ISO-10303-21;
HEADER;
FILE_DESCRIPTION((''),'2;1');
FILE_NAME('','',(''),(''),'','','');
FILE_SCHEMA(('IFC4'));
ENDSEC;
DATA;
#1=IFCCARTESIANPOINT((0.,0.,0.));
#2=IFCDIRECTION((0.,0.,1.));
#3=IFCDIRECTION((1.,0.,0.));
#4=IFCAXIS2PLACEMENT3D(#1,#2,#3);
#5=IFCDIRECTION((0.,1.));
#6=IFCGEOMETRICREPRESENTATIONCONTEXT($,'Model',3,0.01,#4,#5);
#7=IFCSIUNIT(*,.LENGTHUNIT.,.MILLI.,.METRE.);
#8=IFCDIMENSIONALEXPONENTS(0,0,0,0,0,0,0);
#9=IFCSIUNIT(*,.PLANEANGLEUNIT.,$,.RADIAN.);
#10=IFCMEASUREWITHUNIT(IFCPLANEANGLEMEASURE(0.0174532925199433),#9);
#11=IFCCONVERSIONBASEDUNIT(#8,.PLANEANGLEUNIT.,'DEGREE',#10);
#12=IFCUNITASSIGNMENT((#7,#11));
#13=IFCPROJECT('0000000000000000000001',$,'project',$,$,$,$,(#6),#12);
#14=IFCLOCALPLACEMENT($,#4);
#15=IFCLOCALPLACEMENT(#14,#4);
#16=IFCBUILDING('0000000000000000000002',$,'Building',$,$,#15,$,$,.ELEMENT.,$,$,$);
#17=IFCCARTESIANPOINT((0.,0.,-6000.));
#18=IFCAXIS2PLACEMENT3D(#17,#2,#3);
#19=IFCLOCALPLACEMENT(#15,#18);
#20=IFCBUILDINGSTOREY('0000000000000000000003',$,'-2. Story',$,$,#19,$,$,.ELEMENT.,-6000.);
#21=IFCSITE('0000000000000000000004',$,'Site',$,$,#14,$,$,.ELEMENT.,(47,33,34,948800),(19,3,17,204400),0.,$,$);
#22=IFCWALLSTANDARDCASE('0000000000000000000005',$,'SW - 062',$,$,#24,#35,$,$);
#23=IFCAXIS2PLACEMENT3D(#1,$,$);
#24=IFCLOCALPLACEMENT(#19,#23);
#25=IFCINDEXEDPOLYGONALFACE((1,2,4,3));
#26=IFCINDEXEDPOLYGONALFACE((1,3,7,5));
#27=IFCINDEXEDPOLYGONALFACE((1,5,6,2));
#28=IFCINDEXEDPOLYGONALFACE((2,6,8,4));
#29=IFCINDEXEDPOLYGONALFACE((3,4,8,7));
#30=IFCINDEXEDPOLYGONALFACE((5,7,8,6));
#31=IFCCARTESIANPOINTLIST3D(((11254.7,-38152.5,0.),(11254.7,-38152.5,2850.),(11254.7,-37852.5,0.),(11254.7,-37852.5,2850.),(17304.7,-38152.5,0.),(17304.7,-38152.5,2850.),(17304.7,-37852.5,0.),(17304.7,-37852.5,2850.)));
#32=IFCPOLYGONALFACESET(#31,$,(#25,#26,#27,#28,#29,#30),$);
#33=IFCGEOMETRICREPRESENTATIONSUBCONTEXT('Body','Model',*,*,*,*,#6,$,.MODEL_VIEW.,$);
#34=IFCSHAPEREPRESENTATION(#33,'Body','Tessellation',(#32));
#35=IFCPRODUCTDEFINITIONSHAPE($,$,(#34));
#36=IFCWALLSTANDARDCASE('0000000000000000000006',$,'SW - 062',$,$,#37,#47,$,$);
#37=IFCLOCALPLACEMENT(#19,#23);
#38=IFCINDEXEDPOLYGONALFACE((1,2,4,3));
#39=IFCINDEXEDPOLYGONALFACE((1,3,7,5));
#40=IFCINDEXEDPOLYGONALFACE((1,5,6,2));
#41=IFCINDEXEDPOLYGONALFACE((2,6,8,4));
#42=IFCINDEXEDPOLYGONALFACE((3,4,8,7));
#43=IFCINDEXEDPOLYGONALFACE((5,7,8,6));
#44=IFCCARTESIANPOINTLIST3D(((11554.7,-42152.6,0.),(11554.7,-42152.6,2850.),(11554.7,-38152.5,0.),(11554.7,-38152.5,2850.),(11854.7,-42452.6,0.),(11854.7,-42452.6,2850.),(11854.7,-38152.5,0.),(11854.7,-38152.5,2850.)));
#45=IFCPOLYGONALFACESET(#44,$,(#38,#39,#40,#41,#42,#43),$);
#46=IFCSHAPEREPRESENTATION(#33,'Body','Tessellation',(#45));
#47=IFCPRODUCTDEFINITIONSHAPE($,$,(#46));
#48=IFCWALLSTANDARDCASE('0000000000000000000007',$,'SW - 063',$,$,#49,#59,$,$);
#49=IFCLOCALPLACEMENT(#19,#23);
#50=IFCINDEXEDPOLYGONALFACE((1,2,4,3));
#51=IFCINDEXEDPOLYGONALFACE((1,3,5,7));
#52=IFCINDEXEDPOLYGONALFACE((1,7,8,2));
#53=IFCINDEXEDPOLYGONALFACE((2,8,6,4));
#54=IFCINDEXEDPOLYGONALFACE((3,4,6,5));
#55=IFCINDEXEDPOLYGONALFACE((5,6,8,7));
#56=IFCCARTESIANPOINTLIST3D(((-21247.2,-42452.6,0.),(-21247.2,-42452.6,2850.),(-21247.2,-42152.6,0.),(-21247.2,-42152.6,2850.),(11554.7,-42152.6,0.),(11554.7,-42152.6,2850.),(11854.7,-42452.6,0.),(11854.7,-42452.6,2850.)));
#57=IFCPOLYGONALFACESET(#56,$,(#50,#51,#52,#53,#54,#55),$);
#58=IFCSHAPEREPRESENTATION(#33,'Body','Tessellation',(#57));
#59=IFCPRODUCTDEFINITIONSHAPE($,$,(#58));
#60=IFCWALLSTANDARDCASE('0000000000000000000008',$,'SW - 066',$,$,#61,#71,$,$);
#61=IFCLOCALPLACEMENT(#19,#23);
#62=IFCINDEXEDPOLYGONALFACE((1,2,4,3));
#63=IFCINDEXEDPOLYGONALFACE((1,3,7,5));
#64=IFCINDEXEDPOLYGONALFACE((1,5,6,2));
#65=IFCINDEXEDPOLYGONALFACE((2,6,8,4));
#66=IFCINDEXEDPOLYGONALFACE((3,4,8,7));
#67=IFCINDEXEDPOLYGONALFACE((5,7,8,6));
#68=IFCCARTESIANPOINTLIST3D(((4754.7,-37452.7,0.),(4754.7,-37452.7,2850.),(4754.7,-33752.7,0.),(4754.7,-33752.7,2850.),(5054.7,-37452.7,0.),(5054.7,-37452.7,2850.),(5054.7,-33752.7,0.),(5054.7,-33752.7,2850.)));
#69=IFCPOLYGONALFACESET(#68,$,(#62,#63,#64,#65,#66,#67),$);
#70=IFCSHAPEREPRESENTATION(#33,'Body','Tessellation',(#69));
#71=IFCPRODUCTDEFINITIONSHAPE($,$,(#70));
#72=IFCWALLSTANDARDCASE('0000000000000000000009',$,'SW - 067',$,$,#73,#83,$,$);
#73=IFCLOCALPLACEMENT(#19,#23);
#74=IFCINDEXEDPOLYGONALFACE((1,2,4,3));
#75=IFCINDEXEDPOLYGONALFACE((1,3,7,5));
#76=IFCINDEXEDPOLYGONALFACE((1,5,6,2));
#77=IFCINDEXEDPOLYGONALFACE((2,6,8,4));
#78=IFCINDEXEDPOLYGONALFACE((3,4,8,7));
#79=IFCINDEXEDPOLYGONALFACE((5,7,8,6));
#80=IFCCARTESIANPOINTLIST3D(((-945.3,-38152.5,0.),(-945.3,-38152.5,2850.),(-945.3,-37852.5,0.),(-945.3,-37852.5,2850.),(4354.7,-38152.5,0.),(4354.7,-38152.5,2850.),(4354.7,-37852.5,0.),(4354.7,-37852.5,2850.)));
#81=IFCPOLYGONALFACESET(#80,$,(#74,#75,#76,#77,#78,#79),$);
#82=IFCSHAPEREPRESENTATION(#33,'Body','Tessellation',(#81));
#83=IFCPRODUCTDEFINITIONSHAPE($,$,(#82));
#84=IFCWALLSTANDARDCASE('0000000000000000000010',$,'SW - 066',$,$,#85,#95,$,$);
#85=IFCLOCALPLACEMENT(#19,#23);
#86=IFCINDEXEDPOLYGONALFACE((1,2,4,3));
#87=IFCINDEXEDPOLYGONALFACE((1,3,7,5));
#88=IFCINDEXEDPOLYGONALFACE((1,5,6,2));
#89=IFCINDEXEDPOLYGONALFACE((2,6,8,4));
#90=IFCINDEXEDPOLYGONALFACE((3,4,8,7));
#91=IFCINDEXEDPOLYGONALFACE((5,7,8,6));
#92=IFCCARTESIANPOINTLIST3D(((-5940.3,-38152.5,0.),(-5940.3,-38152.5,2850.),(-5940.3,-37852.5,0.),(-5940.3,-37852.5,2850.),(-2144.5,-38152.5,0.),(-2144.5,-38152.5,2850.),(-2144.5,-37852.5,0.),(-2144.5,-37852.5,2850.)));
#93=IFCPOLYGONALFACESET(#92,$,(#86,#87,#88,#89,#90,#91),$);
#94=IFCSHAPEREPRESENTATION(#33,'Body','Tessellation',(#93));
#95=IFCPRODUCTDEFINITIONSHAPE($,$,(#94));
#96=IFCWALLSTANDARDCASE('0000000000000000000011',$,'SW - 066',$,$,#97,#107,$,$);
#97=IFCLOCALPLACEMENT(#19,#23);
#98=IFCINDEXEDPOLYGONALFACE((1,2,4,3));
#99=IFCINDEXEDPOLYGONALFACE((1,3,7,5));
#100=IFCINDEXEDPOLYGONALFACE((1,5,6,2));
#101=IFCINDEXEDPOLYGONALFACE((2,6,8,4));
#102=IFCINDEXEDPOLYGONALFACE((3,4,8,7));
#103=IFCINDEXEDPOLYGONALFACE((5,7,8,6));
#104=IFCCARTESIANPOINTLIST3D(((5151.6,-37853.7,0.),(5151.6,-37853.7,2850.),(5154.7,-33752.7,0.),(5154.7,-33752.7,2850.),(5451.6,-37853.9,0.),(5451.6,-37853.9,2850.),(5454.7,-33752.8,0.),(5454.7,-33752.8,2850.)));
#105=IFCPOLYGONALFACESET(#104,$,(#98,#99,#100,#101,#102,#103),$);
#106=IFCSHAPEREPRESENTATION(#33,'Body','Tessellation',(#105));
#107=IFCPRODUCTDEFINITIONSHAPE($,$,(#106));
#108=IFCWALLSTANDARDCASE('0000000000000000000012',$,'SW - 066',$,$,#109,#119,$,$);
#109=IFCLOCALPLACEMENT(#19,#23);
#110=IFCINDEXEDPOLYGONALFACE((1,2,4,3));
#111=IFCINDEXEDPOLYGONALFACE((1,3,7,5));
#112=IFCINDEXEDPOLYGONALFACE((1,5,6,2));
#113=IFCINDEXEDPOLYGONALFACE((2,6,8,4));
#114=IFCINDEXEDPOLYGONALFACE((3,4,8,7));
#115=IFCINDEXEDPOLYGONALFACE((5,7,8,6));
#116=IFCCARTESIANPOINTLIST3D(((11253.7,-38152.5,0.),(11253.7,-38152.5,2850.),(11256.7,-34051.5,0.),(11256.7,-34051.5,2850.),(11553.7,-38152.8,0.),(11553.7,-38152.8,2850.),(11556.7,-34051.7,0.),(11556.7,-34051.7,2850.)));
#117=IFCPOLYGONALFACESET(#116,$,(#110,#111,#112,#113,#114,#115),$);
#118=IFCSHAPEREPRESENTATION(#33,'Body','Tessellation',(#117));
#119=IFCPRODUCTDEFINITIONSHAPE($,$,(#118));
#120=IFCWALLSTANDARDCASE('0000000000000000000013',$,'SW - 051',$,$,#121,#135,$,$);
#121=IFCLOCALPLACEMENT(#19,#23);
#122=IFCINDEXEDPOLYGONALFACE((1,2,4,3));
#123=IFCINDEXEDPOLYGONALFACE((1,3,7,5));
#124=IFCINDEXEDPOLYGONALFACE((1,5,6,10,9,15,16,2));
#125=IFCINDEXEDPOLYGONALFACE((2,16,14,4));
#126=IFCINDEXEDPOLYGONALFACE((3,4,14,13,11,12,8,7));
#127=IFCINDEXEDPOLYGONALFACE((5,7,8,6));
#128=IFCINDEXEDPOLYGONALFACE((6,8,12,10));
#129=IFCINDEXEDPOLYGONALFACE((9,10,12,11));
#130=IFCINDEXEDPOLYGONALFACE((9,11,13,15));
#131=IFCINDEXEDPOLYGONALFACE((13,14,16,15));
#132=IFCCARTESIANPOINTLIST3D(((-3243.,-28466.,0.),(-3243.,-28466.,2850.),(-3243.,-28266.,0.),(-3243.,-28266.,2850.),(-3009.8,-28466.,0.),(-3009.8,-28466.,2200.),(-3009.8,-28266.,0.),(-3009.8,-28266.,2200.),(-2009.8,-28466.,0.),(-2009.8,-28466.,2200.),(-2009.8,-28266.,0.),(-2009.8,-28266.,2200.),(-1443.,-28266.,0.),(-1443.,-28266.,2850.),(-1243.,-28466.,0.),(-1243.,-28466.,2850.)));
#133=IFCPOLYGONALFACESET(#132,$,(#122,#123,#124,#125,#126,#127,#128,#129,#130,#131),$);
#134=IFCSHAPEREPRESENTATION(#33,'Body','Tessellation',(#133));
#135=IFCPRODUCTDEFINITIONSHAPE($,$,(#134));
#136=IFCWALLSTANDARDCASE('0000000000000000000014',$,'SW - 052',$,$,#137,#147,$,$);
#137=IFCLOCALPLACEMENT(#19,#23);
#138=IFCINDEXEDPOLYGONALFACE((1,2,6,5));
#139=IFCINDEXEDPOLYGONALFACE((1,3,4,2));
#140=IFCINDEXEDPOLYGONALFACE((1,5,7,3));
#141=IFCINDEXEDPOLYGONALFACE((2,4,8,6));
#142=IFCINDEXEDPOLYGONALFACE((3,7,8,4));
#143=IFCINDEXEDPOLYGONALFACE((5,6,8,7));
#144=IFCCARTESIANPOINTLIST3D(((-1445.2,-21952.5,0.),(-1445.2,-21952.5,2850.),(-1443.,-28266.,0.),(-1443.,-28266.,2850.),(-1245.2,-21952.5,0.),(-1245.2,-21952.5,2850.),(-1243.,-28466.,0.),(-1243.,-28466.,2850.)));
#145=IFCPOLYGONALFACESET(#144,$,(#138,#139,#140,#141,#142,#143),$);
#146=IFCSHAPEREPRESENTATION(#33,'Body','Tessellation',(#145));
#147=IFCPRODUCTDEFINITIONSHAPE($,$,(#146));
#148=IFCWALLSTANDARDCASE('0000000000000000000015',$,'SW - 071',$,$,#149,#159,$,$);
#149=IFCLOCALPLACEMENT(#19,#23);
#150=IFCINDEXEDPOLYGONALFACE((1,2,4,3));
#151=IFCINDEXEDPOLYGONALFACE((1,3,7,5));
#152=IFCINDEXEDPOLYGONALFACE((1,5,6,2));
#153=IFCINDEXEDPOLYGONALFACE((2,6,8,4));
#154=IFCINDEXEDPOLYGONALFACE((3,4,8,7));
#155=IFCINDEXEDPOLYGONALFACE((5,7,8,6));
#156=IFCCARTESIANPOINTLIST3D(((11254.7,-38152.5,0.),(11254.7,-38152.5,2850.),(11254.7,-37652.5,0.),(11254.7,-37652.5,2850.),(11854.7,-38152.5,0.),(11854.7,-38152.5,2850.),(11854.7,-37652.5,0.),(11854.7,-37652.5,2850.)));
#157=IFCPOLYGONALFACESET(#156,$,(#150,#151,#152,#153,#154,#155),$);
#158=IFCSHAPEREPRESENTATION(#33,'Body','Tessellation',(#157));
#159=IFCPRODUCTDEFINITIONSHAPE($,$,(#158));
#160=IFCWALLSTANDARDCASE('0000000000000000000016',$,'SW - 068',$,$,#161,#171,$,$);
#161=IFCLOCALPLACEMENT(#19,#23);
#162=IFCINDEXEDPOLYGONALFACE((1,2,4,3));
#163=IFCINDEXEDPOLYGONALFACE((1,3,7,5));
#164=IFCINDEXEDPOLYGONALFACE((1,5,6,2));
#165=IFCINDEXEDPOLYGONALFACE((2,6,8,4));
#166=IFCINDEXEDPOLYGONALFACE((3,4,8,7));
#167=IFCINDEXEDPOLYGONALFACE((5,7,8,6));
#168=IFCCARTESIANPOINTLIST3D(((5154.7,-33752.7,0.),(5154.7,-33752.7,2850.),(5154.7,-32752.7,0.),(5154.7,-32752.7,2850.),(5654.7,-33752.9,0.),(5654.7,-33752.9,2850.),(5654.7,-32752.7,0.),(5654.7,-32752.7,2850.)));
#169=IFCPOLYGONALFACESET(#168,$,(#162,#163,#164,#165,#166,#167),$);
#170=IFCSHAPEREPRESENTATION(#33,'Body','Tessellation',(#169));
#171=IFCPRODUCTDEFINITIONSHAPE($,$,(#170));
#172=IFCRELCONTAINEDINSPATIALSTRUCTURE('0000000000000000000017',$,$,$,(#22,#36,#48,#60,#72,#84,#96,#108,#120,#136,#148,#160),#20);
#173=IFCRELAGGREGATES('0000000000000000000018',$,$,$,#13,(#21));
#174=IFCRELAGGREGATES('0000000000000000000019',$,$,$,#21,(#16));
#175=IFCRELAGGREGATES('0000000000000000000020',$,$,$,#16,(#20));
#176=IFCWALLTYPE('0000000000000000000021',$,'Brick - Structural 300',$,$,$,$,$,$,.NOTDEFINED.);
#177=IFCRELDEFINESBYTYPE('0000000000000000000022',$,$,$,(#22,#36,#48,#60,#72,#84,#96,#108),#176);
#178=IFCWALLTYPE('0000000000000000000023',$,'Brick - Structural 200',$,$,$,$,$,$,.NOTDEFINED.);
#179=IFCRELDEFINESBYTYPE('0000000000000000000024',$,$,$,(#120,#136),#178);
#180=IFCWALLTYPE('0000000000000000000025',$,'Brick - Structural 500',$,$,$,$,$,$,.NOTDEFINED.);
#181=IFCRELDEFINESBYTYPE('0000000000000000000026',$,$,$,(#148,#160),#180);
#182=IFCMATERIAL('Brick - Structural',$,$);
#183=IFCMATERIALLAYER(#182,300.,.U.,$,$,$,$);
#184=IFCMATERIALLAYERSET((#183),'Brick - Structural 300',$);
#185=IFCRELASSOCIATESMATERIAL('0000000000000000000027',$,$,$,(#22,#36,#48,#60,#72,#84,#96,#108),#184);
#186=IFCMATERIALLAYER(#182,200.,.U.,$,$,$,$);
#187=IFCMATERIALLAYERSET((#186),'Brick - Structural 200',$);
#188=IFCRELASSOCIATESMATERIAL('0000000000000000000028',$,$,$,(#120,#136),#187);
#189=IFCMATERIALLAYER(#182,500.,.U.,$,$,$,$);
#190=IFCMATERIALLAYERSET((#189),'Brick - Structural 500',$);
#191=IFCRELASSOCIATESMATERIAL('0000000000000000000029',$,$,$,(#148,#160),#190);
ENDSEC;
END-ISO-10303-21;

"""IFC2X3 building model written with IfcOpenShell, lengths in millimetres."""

from ifc_helpers import new_model, entity, si_unit, converted_unit, direction, frame, origin_with_axes, origin_2d_with_axis, place, context, subcontext, project, spatial, polyline, rectangle, outline, extrude, material, layer, layer_set, layer_usage, type_object, element, save


model = new_model("IFC2X3")

# Units and contexts
model_context = context("Model", 3, precision=0.01, world=origin_with_axes(), true_north=direction((0.0, 1.0)))
body_context = subcontext(model_context, "Body", "Model", "MODEL_VIEW")
ifc_project = project(units=[si_unit("LENGTHUNIT", "METRE", prefix="MILLI"), converted_unit("PLANEANGLEUNIT", "DEGREE", entity("IfcPlaneAngleMeasure", 0.0174532925199433), si_unit("PLANEANGLEUNIT", "RADIAN"), dimensions=[0, 0, 0, 0, 0, 0, 0])], contexts=[model_context])

# Site, building, storey
site_placement = place(None, origin_with_axes())
site = spatial("IfcSite", under=ifc_project, at=site_placement, Name="Site", CompositionType="ELEMENT", RefLatitude=(47, 33, 34, 948800), RefLongitude=(19, 3, 17, 204400), RefElevation=0.0)
building_placement = place(site_placement, origin_with_axes())
building = spatial("IfcBuilding", under=site, at=building_placement, Name="Building", CompositionType="ELEMENT")
storey_placement = place(building_placement, frame((0.0, 0.0, -6000.0), z_axis=(0.0, 0.0, 1.0), x_axis=(1.0, 0.0, 0.0)))
storey = spatial("IfcBuildingStorey", under=building, at=storey_placement, Name="-2. Story", CompositionType="ELEMENT", Elevation=-6000.0)

# Shared definitions
ifc_material_1 = material(Name="Brick - Structural")
ifc_layer_1 = layer(ifc_material_1, 300.0, ventilated="UNKNOWN")
ifc_layer_set_1 = layer_set([ifc_layer_1], Name="Brick - Structural 300")
wall_type_1 = type_object("IfcWallType", Name="Brick - Structural 300", PredefinedType="NOTDEFINED")

# Walls
ifc_layer_usage_1 = layer_usage(ifc_layer_set_1, "AXIS2", "POSITIVE", 0.0)
wall_1_placement = place(storey_placement, frame((11254.7, -38152.5, 0.0), z_axis=(0.0, 0.0, 1.0), x_axis=(1.0, 0.0, 0.0)))
element("IfcWallStandardCase", 1, at=wall_1_placement, inside=storey, type_object=wall_type_1, material=ifc_layer_usage_1, Name="SW - 062", context=body_context, shape_type="SweptSolid", body=[
    extrude(outline(polyline([(0.0, 0.0), (6050.0, 0.0), (6050.0, 300.0), (0.0, 300.0), (0.0, 0.0)])), origin_with_axes(), (0.0, 0.0, 1.0), 2850.0),
])
ifc_layer_usage_2 = layer_usage(ifc_layer_set_1, "AXIS2", "POSITIVE", 0.0)
wall_2_placement = place(storey_placement, frame((11554.7, -38152.5, 0.0), z_axis=(0.0, 0.0, 1.0), x_axis=(0.0, -1.0, 0.0)))
element("IfcWallStandardCase", 2, at=wall_2_placement, inside=storey, type_object=wall_type_1, material=ifc_layer_usage_2, Name="SW - 062", context=body_context, shape_type="SweptSolid", body=[
    extrude(outline(polyline([(0.0, 0.0), (4000.1, 0.0), (4300.1, 300.0), (0.0, 300.0), (0.0, 0.0)])), origin_with_axes(), (0.0, 0.0, 1.0), 2850.0),
])
ifc_layer_usage_3 = layer_usage(ifc_layer_set_1, "AXIS2", "POSITIVE", 0.0)
wall_3_placement = place(storey_placement, frame((11554.7, -42152.6, 0.0), z_axis=(0.0, 0.0, 1.0), x_axis=(-1.0, 0.0, 0.0)))
element("IfcWallStandardCase", 3, at=wall_3_placement, inside=storey, type_object=wall_type_1, material=ifc_layer_usage_3, Name="SW - 063", context=body_context, shape_type="SweptSolid", body=[
    extrude(outline(polyline([(0.0, 0.0), (32801.9, 0.0), (32801.9, 300.0), (-300.0, 300.0), (0.0, 0.0)])), origin_with_axes(), (0.0, 0.0, 1.0), 2850.0),
])
ifc_layer_usage_4 = layer_usage(ifc_layer_set_1, "AXIS2", "POSITIVE", 0.0)
wall_4_placement = place(storey_placement, frame((5054.7, -37452.7, 0.0), z_axis=(0.0, 0.0, 1.0), x_axis=(0.0, 1.0, 0.0)))
element("IfcWallStandardCase", 4, at=wall_4_placement, inside=storey, type_object=wall_type_1, material=ifc_layer_usage_4, Name="SW - 066", context=body_context, shape_type="SweptSolid", body=[
    extrude(outline(polyline([(0.0, 0.0), (3700.0, 0.0), (3700.0, 300.0), (0.0, 300.0), (0.0, 0.0)])), origin_with_axes(), (0.0, 0.0, 1.0), 2850.0),
])
ifc_layer_usage_5 = layer_usage(ifc_layer_set_1, "AXIS2", "POSITIVE", 0.0)
wall_5_placement = place(storey_placement, frame((-945.3, -38152.5, 0.0), z_axis=(0.0, 0.0, 1.0), x_axis=(1.0, 0.0, 0.0)))
element("IfcWallStandardCase", 5, at=wall_5_placement, inside=storey, type_object=wall_type_1, material=ifc_layer_usage_5, Name="SW - 067", context=body_context, shape_type="SweptSolid", body=[
    extrude(outline(polyline([(0.0, 0.0), (5300.0, 0.0), (5300.0, 300.0), (0.0, 300.0), (0.0, 0.0)])), origin_with_axes(), (0.0, 0.0, 1.0), 2850.0),
])
ifc_layer_usage_6 = layer_usage(ifc_layer_set_1, "AXIS2", "POSITIVE", 0.0)
wall_6_placement = place(storey_placement, frame((-5940.3, -38152.5, 0.0), z_axis=(0.0, 0.0, 1.0), x_axis=(1.0, 0.0, 0.0)))
element("IfcWallStandardCase", 6, at=wall_6_placement, inside=storey, type_object=wall_type_1, material=ifc_layer_usage_6, Name="SW - 066", context=body_context, shape_type="SweptSolid", body=[
    extrude(outline(polyline([(0.0, 0.0), (3795.8, 0.0), (3795.8, 300.0), (0.0, 300.0), (0.0, 0.0)])), origin_with_axes(), (0.0, 0.0, 1.0), 2850.0),
])
ifc_layer_usage_7 = layer_usage(ifc_layer_set_1, "AXIS2", "POSITIVE", 0.0)
wall_7_placement = place(storey_placement, frame((5154.7, -33752.7, 0.0), z_axis=(0.0, 0.0, 1.0), x_axis=(-0.000749, -1.0, 0.0)))
element("IfcWallStandardCase", 7, at=wall_7_placement, inside=storey, type_object=wall_type_1, material=ifc_layer_usage_7, Name="SW - 066", context=body_context, shape_type="SweptSolid", body=[
    extrude(outline(polyline([(0.0, 0.0), (4101.0, 0.0), (4101.0, 300.0), (-0.1, 300.0), (0.0, 0.0)])), origin_with_axes(), (0.0, 0.0, 1.0), 2850.0),
])
ifc_layer_usage_8 = layer_usage(ifc_layer_set_1, "AXIS2", "POSITIVE", 0.0)
wall_8_placement = place(storey_placement, frame((11256.7, -34051.5, 0.0), z_axis=(0.0, 0.0, 1.0), x_axis=(-0.000749, -1.0, 0.0)))
element("IfcWallStandardCase", 8, at=wall_8_placement, inside=storey, type_object=wall_type_1, material=ifc_layer_usage_8, Name="SW - 066", context=body_context, shape_type="SweptSolid", body=[
    extrude(outline(polyline([(0.0, 0.0), (4101.0, 0.0), (4101.0, 300.0), (0.0, 300.0), (0.0, 0.0)])), origin_with_axes(), (0.0, 0.0, 1.0), 2850.0),
])

# Wall, opening
ifc_layer_2 = layer(ifc_material_1, 200.0, ventilated="UNKNOWN")
ifc_layer_set_2 = layer_set([ifc_layer_2], Name="Brick - Structural 200")
ifc_layer_usage_9 = layer_usage(ifc_layer_set_2, "AXIS2", "POSITIVE", 0.0)
wall_type_2 = type_object("IfcWallType", Name="Brick - Structural 200", PredefinedType="NOTDEFINED")
wall_9_placement = place(storey_placement, frame((-3243.0, -28466.0, 0.0), z_axis=(0.0, 0.0, 1.0), x_axis=(1.0, 0.0, 0.0)))
wall_9 = element("IfcWallStandardCase", 9, at=wall_9_placement, inside=storey, type_object=wall_type_2, material=ifc_layer_usage_9, Name="SW - 051", context=body_context, shape_type="SweptSolid", body=[
    extrude(outline(polyline([(0.0, 0.0), (2000.0, 0.0), (1799.9, 200.0), (0.0, 200.0), (0.0, 0.0)])), origin_with_axes(), (0.0, 0.0, 1.0), 2850.0),
])
opening_1_placement = place(wall_9_placement, frame((733.2, 0.0, 0.0), z_axis=(0.0, 0.0, 1.0), x_axis=(1.0, 0.0, 0.0)))
element("IfcOpeningElement", 10, at=opening_1_placement, cuts=wall_9, context=body_context, shape_type="SweptSolid", body=[
    extrude(rectangle(XDim=1000.0, YDim=2200.0, at=origin_2d_with_axis()), frame((0.0, 0.0, 1100.0), z_axis=(0.0, 1.0, 0.0), x_axis=(1.0, 0.0, 0.0)), (0.0, 0.0, -1.0), 200.0),
    extrude(rectangle(XDim=1000.0, YDim=2200.0, at=origin_2d_with_axis()), frame((0.0, 0.0, 1100.0), z_axis=(0.0, -1.0, 0.0), x_axis=(1.0, 0.0, 0.0)), (0.0, 0.0, -1.0), 200.0),
])

# Walls
ifc_layer_usage_10 = layer_usage(ifc_layer_set_2, "AXIS2", "POSITIVE", 0.0)
wall_10_placement = place(storey_placement, frame((-1243.0, -28466.0, 0.0), z_axis=(0.0, 0.0, 1.0), x_axis=(-0.000344, 1.0, 0.0)))
element("IfcWallStandardCase", 11, at=wall_10_placement, inside=storey, type_object=wall_type_2, material=ifc_layer_usage_10, Name="SW - 052", context=body_context, shape_type="SweptSolid", body=[
    extrude(outline(polyline([(0.0, 0.0), (6513.4, 0.0), (6513.5, 200.0), (200.1, 200.0), (0.0, 0.0)])), origin_with_axes(), (0.0, 0.0, 1.0), 2850.0),
])
ifc_layer_3 = layer(ifc_material_1, 500.0, ventilated="UNKNOWN")
ifc_layer_set_3 = layer_set([ifc_layer_3], Name="Brick - Structural 500")
ifc_layer_usage_11 = layer_usage(ifc_layer_set_3, "AXIS2", "POSITIVE", 0.0)
wall_type_3 = type_object("IfcWallType", Name="Brick - Structural 500", PredefinedType="NOTDEFINED")
wall_11_placement = place(storey_placement, frame((11254.7, -38152.5, 0.0), z_axis=(0.0, 0.0, 1.0), x_axis=(1.0, 0.0, 0.0)))
element("IfcWallStandardCase", 12, at=wall_11_placement, inside=storey, type_object=wall_type_3, material=ifc_layer_usage_11, Name="SW - 071", context=body_context, shape_type="SweptSolid", body=[
    extrude(outline(polyline([(0.0, 0.0), (600.0, 0.0), (600.0, 500.0), (0.0, 500.0), (0.0, 0.0)])), origin_with_axes(), (0.0, 0.0, 1.0), 2850.0),
])
ifc_layer_usage_12 = layer_usage(ifc_layer_set_3, "AXIS2", "POSITIVE", 0.0)
wall_12_placement = place(storey_placement, frame((5154.7, -32752.7, 0.0), z_axis=(0.0, 0.0, 1.0), x_axis=(0.0, -1.0, 0.0)))
element("IfcWallStandardCase", 13, at=wall_12_placement, inside=storey, type_object=wall_type_3, material=ifc_layer_usage_12, Name="SW - 068", context=body_context, shape_type="SweptSolid", body=[
    extrude(outline(polyline([(0.0, 0.0), (1000.0, 0.0), (1000.2, 500.0), (0.0, 500.0), (0.0, 0.0)])), origin_with_axes(), (0.0, 0.0, 1.0), 2850.0),
])

save(model, "model.ifc")
